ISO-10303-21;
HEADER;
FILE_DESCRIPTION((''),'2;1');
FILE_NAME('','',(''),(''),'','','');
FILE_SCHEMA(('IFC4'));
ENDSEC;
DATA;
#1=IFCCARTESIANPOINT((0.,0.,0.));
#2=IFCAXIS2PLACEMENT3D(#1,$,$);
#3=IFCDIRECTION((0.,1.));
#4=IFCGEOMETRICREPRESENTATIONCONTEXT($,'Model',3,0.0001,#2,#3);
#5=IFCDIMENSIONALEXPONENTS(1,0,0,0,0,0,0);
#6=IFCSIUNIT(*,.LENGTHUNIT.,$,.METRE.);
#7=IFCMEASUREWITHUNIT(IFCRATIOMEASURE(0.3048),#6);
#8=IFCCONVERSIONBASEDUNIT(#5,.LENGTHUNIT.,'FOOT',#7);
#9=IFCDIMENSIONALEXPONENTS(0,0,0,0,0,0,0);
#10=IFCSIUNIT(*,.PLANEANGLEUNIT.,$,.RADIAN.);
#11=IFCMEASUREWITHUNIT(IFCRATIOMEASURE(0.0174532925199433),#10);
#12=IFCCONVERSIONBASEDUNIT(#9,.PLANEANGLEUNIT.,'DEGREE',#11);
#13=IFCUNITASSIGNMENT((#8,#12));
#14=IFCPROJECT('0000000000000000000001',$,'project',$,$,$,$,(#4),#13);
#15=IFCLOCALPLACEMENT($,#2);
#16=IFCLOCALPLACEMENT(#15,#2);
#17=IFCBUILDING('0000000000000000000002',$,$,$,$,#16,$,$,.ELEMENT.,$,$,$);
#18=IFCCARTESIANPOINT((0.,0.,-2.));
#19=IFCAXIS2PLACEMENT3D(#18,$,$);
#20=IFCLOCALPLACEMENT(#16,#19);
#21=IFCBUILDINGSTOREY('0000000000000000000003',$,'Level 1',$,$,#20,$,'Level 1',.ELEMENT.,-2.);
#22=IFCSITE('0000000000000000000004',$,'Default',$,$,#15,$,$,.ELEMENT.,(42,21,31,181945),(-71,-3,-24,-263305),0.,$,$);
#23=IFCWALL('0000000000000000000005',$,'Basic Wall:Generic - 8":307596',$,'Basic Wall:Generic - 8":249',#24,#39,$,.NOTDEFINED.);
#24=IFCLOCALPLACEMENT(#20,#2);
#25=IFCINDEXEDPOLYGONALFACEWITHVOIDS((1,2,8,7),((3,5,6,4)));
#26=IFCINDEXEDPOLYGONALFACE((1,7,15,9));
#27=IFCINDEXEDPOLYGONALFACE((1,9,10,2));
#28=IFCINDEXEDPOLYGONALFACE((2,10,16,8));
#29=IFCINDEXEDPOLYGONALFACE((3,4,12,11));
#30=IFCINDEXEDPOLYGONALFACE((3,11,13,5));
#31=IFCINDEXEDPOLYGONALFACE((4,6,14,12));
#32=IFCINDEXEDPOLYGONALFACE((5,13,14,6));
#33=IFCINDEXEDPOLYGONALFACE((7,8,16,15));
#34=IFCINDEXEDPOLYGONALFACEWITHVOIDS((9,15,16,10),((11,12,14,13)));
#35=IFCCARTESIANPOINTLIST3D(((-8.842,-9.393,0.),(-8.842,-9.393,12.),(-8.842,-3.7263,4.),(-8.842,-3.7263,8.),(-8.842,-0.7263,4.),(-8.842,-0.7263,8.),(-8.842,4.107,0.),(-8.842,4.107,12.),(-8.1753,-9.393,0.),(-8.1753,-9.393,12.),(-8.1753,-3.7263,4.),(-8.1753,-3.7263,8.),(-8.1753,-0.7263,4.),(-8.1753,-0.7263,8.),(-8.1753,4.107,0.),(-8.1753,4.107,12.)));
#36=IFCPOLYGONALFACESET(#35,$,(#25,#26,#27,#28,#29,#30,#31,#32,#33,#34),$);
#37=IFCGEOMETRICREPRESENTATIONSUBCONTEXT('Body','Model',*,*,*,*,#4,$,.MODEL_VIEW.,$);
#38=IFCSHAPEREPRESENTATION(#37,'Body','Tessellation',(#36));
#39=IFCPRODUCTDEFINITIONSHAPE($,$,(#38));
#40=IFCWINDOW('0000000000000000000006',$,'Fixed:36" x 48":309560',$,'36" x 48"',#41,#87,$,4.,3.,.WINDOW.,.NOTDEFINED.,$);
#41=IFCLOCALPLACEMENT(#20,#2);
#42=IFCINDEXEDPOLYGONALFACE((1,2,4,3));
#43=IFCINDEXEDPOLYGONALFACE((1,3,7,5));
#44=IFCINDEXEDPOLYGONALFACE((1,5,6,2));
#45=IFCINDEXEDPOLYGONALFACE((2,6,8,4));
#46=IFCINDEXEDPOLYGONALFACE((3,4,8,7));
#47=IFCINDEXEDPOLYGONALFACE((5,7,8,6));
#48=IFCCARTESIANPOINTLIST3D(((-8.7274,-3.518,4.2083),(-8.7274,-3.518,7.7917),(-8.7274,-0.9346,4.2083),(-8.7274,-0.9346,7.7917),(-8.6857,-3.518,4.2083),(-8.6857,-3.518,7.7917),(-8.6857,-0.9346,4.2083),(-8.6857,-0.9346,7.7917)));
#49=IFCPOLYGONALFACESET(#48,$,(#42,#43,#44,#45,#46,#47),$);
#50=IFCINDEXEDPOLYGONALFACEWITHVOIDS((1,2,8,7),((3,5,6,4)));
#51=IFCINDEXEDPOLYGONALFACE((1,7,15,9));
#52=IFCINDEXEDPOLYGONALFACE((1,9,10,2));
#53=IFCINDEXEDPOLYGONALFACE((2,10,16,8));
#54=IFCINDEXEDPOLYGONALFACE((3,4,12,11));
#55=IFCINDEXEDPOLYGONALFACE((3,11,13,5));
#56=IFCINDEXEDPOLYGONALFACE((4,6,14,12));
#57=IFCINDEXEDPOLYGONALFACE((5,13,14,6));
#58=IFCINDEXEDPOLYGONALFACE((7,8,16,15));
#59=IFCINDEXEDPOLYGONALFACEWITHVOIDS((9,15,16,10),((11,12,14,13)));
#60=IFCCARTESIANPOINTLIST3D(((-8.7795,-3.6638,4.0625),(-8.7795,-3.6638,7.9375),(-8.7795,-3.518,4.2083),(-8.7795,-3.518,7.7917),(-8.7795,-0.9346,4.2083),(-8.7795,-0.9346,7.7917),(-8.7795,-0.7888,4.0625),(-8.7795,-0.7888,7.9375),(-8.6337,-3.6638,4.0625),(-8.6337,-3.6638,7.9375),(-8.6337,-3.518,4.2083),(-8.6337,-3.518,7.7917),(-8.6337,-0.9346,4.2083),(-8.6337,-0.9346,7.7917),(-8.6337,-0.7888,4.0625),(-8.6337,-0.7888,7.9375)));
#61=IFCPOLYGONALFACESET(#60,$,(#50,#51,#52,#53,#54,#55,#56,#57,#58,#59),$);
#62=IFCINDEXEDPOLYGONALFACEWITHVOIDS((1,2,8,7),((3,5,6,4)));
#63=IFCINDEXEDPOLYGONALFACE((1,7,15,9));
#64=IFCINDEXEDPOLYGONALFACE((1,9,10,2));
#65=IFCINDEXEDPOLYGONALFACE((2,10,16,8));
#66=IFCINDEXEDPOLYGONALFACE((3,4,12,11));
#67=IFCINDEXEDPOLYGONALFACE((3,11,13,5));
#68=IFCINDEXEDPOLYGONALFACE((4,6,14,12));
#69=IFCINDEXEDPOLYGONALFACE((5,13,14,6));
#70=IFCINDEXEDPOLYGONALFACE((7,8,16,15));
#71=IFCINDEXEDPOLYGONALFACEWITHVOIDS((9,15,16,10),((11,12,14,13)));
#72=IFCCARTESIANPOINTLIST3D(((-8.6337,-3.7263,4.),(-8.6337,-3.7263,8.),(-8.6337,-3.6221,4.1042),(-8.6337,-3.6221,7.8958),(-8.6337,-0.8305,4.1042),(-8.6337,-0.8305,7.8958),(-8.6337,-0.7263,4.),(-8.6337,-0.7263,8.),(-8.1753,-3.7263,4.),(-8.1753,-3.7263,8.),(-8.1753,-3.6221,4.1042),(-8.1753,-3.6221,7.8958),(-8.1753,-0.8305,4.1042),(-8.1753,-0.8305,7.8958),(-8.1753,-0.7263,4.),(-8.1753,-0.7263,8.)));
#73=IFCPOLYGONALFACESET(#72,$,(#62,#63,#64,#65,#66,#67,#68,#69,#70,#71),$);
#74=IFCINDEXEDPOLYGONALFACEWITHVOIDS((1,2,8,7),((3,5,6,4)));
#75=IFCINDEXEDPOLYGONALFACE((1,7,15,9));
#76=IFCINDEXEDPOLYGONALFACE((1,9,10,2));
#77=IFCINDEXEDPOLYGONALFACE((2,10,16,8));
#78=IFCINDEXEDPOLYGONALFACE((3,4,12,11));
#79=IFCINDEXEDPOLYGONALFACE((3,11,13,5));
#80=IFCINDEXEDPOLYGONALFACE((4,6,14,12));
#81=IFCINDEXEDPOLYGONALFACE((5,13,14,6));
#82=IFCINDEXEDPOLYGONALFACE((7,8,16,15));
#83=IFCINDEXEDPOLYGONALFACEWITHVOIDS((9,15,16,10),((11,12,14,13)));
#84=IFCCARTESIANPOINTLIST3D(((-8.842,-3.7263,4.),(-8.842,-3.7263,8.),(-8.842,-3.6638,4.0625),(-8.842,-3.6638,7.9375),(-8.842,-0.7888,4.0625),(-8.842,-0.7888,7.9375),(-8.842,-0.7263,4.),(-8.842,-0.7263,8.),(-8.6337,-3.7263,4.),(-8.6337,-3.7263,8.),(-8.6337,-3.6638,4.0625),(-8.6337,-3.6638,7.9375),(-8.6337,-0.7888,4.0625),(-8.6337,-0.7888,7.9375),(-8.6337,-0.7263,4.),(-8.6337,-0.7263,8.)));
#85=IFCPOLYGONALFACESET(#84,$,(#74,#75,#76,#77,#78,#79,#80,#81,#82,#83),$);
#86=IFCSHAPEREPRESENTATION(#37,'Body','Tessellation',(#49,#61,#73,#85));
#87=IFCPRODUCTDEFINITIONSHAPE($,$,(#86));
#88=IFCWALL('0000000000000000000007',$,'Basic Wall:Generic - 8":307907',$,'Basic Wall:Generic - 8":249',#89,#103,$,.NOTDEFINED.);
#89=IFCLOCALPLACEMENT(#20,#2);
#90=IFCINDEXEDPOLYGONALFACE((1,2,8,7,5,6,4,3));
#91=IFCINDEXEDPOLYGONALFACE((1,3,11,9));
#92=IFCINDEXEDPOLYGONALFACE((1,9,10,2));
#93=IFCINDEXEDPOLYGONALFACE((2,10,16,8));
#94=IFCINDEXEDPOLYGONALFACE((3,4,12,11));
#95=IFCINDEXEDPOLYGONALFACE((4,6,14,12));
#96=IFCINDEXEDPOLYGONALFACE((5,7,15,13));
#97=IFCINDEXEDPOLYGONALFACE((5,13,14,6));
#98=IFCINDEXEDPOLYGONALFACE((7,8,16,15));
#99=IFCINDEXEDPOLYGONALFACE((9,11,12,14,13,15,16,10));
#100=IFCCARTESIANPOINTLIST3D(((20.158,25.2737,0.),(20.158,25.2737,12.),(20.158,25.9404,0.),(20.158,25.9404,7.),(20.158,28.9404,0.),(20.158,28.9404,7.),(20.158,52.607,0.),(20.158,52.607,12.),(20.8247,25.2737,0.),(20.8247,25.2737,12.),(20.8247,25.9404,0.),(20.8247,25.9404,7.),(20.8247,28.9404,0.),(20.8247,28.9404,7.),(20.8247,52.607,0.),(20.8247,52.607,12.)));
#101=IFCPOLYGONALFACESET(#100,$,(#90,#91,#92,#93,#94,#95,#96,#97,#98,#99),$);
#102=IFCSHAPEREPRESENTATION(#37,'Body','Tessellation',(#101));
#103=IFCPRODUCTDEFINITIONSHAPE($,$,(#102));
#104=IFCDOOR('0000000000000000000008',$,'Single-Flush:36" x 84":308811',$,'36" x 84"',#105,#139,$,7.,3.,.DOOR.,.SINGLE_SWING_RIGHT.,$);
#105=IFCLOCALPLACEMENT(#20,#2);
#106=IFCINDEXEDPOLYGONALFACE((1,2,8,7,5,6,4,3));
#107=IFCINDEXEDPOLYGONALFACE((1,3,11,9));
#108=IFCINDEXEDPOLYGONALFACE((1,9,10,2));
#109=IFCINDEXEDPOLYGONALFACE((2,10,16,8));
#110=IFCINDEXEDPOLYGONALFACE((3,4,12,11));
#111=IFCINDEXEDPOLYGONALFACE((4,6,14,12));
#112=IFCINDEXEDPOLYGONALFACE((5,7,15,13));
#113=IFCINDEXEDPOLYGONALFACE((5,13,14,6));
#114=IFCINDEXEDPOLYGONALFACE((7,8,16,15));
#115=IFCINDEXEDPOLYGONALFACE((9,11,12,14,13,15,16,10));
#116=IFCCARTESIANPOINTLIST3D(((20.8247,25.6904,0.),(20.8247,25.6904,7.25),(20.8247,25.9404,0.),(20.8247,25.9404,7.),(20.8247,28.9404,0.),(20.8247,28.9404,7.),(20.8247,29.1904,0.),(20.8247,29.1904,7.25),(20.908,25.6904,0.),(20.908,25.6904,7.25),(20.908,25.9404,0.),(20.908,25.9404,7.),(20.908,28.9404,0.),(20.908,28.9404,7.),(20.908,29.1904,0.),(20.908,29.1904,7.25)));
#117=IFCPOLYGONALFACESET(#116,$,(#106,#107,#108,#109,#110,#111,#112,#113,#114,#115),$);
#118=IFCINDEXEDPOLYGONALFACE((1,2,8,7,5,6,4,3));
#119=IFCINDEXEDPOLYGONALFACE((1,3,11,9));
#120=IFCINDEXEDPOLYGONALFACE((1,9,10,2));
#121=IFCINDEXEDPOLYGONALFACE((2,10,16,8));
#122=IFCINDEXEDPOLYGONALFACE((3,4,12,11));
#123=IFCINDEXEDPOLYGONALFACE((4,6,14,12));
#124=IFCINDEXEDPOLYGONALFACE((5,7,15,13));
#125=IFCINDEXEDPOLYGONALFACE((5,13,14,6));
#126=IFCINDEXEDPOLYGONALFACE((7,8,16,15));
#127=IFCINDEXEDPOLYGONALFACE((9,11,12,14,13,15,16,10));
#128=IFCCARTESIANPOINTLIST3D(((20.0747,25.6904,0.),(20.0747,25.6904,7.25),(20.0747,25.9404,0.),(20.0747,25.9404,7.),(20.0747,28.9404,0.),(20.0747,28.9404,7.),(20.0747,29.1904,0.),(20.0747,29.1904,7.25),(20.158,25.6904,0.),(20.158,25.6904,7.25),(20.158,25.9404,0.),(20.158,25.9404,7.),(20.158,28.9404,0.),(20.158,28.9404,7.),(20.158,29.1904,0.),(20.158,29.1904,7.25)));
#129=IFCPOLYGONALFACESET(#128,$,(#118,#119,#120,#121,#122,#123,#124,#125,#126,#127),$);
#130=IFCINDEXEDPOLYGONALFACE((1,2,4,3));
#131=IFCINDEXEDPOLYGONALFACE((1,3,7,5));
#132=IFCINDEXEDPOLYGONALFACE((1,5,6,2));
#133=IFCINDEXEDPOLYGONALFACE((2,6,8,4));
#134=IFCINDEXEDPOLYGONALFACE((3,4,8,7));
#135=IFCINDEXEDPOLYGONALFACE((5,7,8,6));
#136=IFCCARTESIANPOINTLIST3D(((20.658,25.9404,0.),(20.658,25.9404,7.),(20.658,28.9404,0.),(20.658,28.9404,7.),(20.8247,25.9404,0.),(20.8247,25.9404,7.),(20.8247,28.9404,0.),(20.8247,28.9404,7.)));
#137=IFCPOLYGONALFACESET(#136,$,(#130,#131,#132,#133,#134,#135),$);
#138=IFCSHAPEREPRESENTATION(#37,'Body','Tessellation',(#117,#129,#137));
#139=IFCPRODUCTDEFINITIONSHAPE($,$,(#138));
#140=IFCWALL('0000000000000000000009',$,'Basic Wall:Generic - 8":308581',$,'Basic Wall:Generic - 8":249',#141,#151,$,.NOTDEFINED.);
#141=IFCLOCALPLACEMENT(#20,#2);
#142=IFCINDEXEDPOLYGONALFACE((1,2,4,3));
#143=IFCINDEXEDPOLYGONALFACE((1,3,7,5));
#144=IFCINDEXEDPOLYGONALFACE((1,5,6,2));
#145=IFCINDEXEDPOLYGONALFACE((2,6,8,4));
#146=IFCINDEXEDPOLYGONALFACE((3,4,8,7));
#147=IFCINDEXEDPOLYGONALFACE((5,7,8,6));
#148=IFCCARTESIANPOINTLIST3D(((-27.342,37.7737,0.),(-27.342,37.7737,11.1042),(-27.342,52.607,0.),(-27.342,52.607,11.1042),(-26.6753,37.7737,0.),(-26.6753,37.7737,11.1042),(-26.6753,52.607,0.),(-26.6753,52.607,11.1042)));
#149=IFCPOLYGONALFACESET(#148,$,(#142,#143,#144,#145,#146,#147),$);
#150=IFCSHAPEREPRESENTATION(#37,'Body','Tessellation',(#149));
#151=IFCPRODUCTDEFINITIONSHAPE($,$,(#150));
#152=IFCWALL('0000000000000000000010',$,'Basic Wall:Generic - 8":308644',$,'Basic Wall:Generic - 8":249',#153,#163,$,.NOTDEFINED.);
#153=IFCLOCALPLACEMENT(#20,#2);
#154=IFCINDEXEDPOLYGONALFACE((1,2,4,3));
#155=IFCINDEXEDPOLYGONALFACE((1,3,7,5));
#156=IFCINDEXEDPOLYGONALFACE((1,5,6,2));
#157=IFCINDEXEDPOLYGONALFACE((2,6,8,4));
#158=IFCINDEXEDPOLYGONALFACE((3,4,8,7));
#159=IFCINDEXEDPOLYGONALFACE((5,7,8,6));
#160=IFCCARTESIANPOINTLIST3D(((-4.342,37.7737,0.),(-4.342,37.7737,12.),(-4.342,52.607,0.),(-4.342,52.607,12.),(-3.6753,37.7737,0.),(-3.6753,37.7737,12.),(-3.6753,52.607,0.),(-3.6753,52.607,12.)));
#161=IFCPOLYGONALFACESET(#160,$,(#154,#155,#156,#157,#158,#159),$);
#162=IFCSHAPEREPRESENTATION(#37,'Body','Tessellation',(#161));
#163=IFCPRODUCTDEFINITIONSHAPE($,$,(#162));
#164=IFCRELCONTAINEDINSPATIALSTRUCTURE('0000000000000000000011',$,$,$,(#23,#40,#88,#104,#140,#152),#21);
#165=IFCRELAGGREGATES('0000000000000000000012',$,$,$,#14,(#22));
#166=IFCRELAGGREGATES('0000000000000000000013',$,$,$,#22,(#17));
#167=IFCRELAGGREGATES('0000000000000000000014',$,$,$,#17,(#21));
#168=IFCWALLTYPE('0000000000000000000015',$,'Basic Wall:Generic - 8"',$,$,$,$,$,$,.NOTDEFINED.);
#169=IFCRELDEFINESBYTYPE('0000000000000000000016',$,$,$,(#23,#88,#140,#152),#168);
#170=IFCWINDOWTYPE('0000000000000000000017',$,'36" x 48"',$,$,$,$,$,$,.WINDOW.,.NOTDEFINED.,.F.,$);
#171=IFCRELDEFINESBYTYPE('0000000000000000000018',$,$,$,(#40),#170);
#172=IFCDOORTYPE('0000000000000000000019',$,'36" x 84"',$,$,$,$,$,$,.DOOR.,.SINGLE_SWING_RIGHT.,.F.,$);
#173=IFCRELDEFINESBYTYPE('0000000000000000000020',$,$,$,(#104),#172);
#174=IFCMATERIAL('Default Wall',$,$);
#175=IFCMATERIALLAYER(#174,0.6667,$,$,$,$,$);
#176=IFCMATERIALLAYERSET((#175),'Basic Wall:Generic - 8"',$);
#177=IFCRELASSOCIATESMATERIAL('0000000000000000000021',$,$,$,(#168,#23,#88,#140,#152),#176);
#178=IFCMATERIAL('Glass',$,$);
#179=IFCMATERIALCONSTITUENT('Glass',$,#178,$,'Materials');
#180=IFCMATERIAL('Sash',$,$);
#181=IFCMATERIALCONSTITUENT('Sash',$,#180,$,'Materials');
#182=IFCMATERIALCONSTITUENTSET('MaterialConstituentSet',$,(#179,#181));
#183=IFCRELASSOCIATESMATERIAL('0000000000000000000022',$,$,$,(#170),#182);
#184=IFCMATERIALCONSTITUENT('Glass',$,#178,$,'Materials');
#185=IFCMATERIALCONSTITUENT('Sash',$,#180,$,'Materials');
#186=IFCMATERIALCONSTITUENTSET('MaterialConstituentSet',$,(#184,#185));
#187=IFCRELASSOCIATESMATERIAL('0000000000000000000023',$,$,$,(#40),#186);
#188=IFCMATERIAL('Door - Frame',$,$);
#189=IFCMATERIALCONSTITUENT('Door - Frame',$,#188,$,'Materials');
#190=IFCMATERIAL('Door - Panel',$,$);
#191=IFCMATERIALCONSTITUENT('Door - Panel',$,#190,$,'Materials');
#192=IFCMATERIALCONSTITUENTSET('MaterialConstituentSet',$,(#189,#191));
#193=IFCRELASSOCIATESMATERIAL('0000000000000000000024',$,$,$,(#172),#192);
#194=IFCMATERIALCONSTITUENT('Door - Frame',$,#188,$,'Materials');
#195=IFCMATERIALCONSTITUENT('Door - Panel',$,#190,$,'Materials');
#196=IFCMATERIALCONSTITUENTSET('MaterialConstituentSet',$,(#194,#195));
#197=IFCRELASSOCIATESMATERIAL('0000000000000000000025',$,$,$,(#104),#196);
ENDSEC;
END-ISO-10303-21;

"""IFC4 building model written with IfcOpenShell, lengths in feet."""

from ifc_helpers import new_model, entity, si_unit, converted_unit, direction, frame, frame_2d, origin, place, context, subcontext, project, spatial, polyline, rectangle, outline, extrude, clip, bounded_halfspace, source, transform, mapped, material, layer, layer_set, layer_usage, constituent, constituent_set, type_object, type_shapes, element, fill, save


model = new_model("IFC4")

# Units and contexts
model_context = context("Model", 3, precision=0.0001, world=origin(), true_north=direction((0.0, 1.0)))
body_context = subcontext(model_context, "Body", "Model", "MODEL_VIEW")
ifc_project = project(units=[converted_unit("LENGTHUNIT", "FOOT", entity("IfcRatioMeasure", 0.3048), si_unit("LENGTHUNIT", "METRE"), dimensions=[1, 0, 0, 0, 0, 0, 0]), converted_unit("PLANEANGLEUNIT", "DEGREE", entity("IfcRatioMeasure", 0.0174532925199433), si_unit("PLANEANGLEUNIT", "RADIAN"), dimensions=[0, 0, 0, 0, 0, 0, 0])], contexts=[model_context])

# Site, building, storey
site_placement = place(None, origin())
site = spatial("IfcSite", under=ifc_project, at=site_placement, Name="Default", CompositionType="ELEMENT", RefLatitude=(42, 21, 31, 181945), RefLongitude=(-71, -3, -24, -263305), RefElevation=0.0)
building_placement = place(site_placement, origin())
building = spatial("IfcBuilding", under=site, at=building_placement, CompositionType="ELEMENT")
storey_placement = place(building_placement, frame((0.0, 0.0, -2.0)))
storey = spatial("IfcBuildingStorey", under=building, at=storey_placement, Name="Level 1", LongName="Level 1", CompositionType="ELEMENT", Elevation=-2.0)

# Shared definitions
ifc_material_1 = material(Name="Default Wall")
ifc_layer = layer(ifc_material_1, 0.6667)
ifc_layer_set = layer_set([ifc_layer], Name="Basic Wall:Generic - 8\"")
wall_type = type_object("IfcWallType", Name="Basic Wall:Generic - 8\"", PredefinedType="NOTDEFINED", material=ifc_layer_set)
ifc_material_2 = material(Name="Glass")
ifc_material_3 = material(Name="Sash")
ifc_constituent_1 = constituent(ifc_material_2, Name="Glass", Category="Materials")
ifc_constituent_2 = constituent(ifc_material_3, Name="Sash", Category="Materials")
ifc_constituent_set_1 = constituent_set(constituents=[ifc_constituent_1, ifc_constituent_2], Name="MaterialConstituentSet")
window_type_1 = type_object("IfcWindowType", Name="36\" x 48\"", ParameterTakesPrecedence=False, PartitioningType="NOTDEFINED", PredefinedType="WINDOW", material=ifc_constituent_set_1)
shared_shape_1 = source(origin(), body_context, "Body", "SweptSolid", [
    extrude(rectangle(XDim=0.0417, YDim=2.5833, at=frame_2d((0.0, 0.0), x_axis=(1.0, 0.0))), frame((1.5, 0.5312, 0.2083), z_axis=(0.0, 0.0, 1.0), x_axis=(0.0, 1.0, 0.0)), (0.0, 0.0, 1.0), 3.5833),
    extrude(outline(polyline([(-1.4375, -1.9375), (1.4375, -1.9375), (1.4375, 1.9375), (-1.4375, 1.9375), (-1.4375, -1.9375)]), holes=[polyline([(-1.2917, -1.7917), (-1.2917, 1.7917), (1.2917, 1.7917), (1.2917, -1.7917), (-1.2917, -1.7917)])]), frame((1.5, 0.4583, 2.0), z_axis=(0.0, 1.0, 0.0), x_axis=(1.0, 0.0, 0.0)), (0.0, 0.0, 1.0), 0.1458),
    extrude(outline(polyline([(-1.5, -2.0), (1.5, -2.0), (1.5, 2.0), (-1.5, 2.0), (-1.5, -2.0)]), holes=[polyline([(-1.3958, -1.8958), (-1.3958, 1.8958), (1.3958, 1.8958), (1.3958, -1.8958), (-1.3958, -1.8958)])]), frame((1.5, 0.0, 2.0), z_axis=(0.0, 1.0, 0.0), x_axis=(1.0, 0.0, 0.0)), (0.0, 0.0, 1.0), 0.4583),
    extrude(outline(polyline([(-2.0, -1.5), (2.0, -1.5), (2.0, 1.5), (-2.0, 1.5), (-2.0, -1.5)]), holes=[polyline([(-1.9375, -1.4375), (-1.9375, 1.4375), (1.9375, 1.4375), (1.9375, -1.4375), (-1.9375, -1.4375)])]), frame((1.5, 0.4583, 2.0), z_axis=(0.0, 1.0, 0.0), x_axis=(0.0, 0.0, -1.0)), (0.0, 0.0, 1.0), 0.2083),
])
type_shapes(window_type_1, [shared_shape_1])

# Shared definitions
ifc_material_4 = material(Name="Door - Frame")
ifc_material_5 = material(Name="Door - Panel")

# Wall, opening, window
ifc_layer_usage_1 = layer_usage(ifc_layer_set, "AXIS2", "NEGATIVE", 0.3333)
wall_1_placement = place(storey_placement, frame((-8.5087, -9.393, 0.0), z_axis=(0.0, 0.0, 1.0), x_axis=(0.0, 1.0, 0.0)))
wall_1 = element("IfcWall", 1, at=wall_1_placement, inside=storey, type_object=wall_type, material=ifc_layer_usage_1, Name="Basic Wall:Generic - 8\":307596", ObjectType="Basic Wall:Generic - 8\":249", PredefinedType="NOTDEFINED", context=body_context, shape_type="SweptSolid", body=[
    extrude(rectangle(XDim=13.5, YDim=0.6667, at=frame_2d((6.75, 0.0), x_axis=(-1.0, 0.0))), origin(), (0.0, 0.0, 1.0), 12.0),
])
opening_1_placement = place(wall_1_placement, frame((5.6667, -0.3333, 4.0)))
opening_1 = element("IfcOpeningElement", 2, at=opening_1_placement, cuts=wall_1, ObjectType="Opening", PredefinedType="OPENING", context=body_context, shape_type="SweptSolid", body=[
    extrude(rectangle(XDim=4.0, YDim=3.0, at=frame_2d((2.0, 1.5), x_axis=(-1.0, 0.0))), frame((0.0, 0.0, 0.0), z_axis=(0.0, 1.0, 0.0), x_axis=(0.0, 0.0, 1.0)), (0.0, 0.0, 1.0), 0.6667),
])
ifc_constituent_3 = constituent(ifc_material_2, Name="Glass", Category="Materials")
ifc_constituent_4 = constituent(ifc_material_3, Name="Sash", Category="Materials")
ifc_constituent_set_2 = constituent_set(constituents=[ifc_constituent_3, ifc_constituent_4], Name="MaterialConstituentSet")
window_1_placement = place(opening_1_placement, origin())
window_1 = element("IfcWindow", 3, at=window_1_placement, inside=storey, type_object=window_type_1, material=ifc_constituent_set_2, Name="Fixed:36\" x 48\":309560", ObjectType="36\" x 48\"", OverallHeight=4.0, OverallWidth=3.0, PartitioningType="NOTDEFINED", PredefinedType="WINDOW", context=body_context, shape_type="MappedRepresentation", body=[
    mapped(shared_shape_1, transform((0.0, 0.0, 0.0), scale=1.0)),
])
fill(opening_1, window_1)

# Wall, opening, door
ifc_layer_usage_2 = layer_usage(ifc_layer_set, "AXIS2", "NEGATIVE", 0.3333)
wall_2_placement = place(storey_placement, frame((20.4913, 52.607, 0.0), z_axis=(0.0, 0.0, 1.0), x_axis=(0.0, -1.0, 0.0)))
wall_2 = element("IfcWall", 4, at=wall_2_placement, inside=storey, type_object=wall_type, material=ifc_layer_usage_2, Name="Basic Wall:Generic - 8\":307907", ObjectType="Basic Wall:Generic - 8\":249", PredefinedType="NOTDEFINED", context=body_context, shape_type="SweptSolid", body=[
    extrude(rectangle(XDim=27.3333, YDim=0.6667, at=frame_2d((13.6667, 0.0), x_axis=(-1.0, 0.0))), origin(), (0.0, 0.0, 1.0), 12.0),
])
opening_2_placement = place(wall_2_placement, frame((23.6667, -0.3333, 0.0)))
opening_2 = element("IfcOpeningElement", 5, at=opening_2_placement, cuts=wall_2, ObjectType="Opening", PredefinedType="OPENING", context=body_context, shape_type="SweptSolid", body=[
    extrude(rectangle(XDim=3.0, YDim=7.0, at=frame_2d((3.5, 1.5), x_axis=(0.0, 1.0))), frame((0.0, 0.0, 0.0), z_axis=(0.0, 1.0, 0.0), x_axis=(0.0, 0.0, 1.0)), (0.0, 0.0, 1.0), 0.6667),
])
ifc_constituent_5 = constituent(ifc_material_4, Name="Door - Frame", Category="Materials")
ifc_constituent_6 = constituent(ifc_material_5, Name="Door - Panel", Category="Materials")
ifc_constituent_set_3 = constituent_set(constituents=[ifc_constituent_5, ifc_constituent_6], Name="MaterialConstituentSet")
ifc_constituent_7 = constituent(ifc_material_4, Name="Door - Frame", Category="Materials")
ifc_constituent_8 = constituent(ifc_material_5, Name="Door - Panel", Category="Materials")
ifc_constituent_set_4 = constituent_set(constituents=[ifc_constituent_7, ifc_constituent_8], Name="MaterialConstituentSet")
door_type_1 = type_object("IfcDoorType", Name="36\" x 84\"", OperationType="SINGLE_SWING_RIGHT", ParameterTakesPrecedence=False, PredefinedType="DOOR", material=ifc_constituent_set_4)
shared_shape_2 = source(origin(), body_context, "Body", "SweptSolid", [
    extrude(outline(polyline([(-1.75, -3.6875), (1.75, -3.6875), (1.75, 3.5625), (1.5, 3.5625), (1.5, -3.4375), (-1.5, -3.4375), (-1.5, 3.5625), (-1.75, 3.5625), (-1.75, -3.6875)])), frame((1.5, 0.6667, 3.5625), z_axis=(0.0, 1.0, 0.0), x_axis=(1.0, 0.0, 0.0)), (0.0, 0.0, 1.0), 0.0833),
    extrude(outline(polyline([(-3.6875, -1.75), (3.5625, -1.75), (3.5625, -1.5), (-3.4375, -1.5), (-3.4375, 1.5), (3.5625, 1.5), (3.5625, 1.75), (-3.6875, 1.75), (-3.6875, -1.75)])), frame((1.5, -0.0833, 3.5625), z_axis=(0.0, 1.0, 0.0), x_axis=(0.0, 0.0, -1.0)), (0.0, 0.0, 1.0), 0.0833),
    extrude(rectangle(XDim=0.1667, YDim=3.0, at=frame_2d((0.0, 0.0), x_axis=(1.0, 0.0))), frame((1.5, 0.5833, 0.0), z_axis=(0.0, 0.0, 1.0), x_axis=(0.0, 1.0, 0.0)), (0.0, 0.0, 1.0), 7.0),
])
type_shapes(door_type_1, [shared_shape_2])
door_1_placement = place(opening_2_placement, origin())
door_1 = element("IfcDoor", 6, at=door_1_placement, inside=storey, type_object=door_type_1, material=ifc_constituent_set_3, Name="Single-Flush:36\" x 84\":308811", ObjectType="36\" x 84\"", OperationType="SINGLE_SWING_RIGHT", OverallHeight=7.0, OverallWidth=3.0, PredefinedType="DOOR", context=body_context, shape_type="MappedRepresentation", body=[
    mapped(shared_shape_2, transform((0.0, 0.0, 0.0), scale=1.0)),
])
fill(opening_2, door_1)

# Walls
ifc_layer_usage_3 = layer_usage(ifc_layer_set, "AXIS2", "NEGATIVE", 0.3333)
wall_3_placement = place(storey_placement, frame((-27.0087, 37.7737, 0.0), z_axis=(0.0, 0.0, 1.0), x_axis=(0.0, 1.0, 0.0)))
element("IfcWall", 7, at=wall_3_placement, inside=storey, type_object=wall_type, material=ifc_layer_usage_3, Name="Basic Wall:Generic - 8\":308581", ObjectType="Basic Wall:Generic - 8\":249", PredefinedType="NOTDEFINED", context=body_context, shape_type="Clipping", body=[
    clip(extrude(rectangle(XDim=14.8333, YDim=0.6667, at=frame_2d((7.4167, 0.0), x_axis=(-1.0, 0.0))), origin(), (0.0, 0.0, 1.0), 11.1042), bounded_halfspace(frame((0.0, -0.3333, 11.1042), z_axis=(0.0, 0.0, -1.0), x_axis=(-1.0, 0.0, 0.0)), True, frame((0.0, -0.3333, 11.1042), z_axis=(0.0, 0.0, -1.0), x_axis=(-1.0, 0.0, 0.0)), polyline([(0.0, 0.0), (0.0, 0.6667), (-14.8333, 0.6667), (-14.8333, 0.0), (0.0, 0.0)]))),
])
ifc_layer_usage_4 = layer_usage(ifc_layer_set, "AXIS2", "NEGATIVE", 0.3333)
wall_4_placement = place(storey_placement, frame((-4.0087, 37.7737, 0.0), z_axis=(0.0, 0.0, 1.0), x_axis=(0.0, 1.0, 0.0)))
element("IfcWall", 8, at=wall_4_placement, inside=storey, type_object=wall_type, material=ifc_layer_usage_4, Name="Basic Wall:Generic - 8\":308644", ObjectType="Basic Wall:Generic - 8\":249", PredefinedType="NOTDEFINED", context=body_context, shape_type="SweptSolid", body=[
    extrude(rectangle(XDim=14.8333, YDim=0.6667, at=frame_2d((7.4167, 0.0), x_axis=(-1.0, 0.0))), origin(), (0.0, 0.0, 1.0), 12.0),
])

save(model, "model.ifc")
